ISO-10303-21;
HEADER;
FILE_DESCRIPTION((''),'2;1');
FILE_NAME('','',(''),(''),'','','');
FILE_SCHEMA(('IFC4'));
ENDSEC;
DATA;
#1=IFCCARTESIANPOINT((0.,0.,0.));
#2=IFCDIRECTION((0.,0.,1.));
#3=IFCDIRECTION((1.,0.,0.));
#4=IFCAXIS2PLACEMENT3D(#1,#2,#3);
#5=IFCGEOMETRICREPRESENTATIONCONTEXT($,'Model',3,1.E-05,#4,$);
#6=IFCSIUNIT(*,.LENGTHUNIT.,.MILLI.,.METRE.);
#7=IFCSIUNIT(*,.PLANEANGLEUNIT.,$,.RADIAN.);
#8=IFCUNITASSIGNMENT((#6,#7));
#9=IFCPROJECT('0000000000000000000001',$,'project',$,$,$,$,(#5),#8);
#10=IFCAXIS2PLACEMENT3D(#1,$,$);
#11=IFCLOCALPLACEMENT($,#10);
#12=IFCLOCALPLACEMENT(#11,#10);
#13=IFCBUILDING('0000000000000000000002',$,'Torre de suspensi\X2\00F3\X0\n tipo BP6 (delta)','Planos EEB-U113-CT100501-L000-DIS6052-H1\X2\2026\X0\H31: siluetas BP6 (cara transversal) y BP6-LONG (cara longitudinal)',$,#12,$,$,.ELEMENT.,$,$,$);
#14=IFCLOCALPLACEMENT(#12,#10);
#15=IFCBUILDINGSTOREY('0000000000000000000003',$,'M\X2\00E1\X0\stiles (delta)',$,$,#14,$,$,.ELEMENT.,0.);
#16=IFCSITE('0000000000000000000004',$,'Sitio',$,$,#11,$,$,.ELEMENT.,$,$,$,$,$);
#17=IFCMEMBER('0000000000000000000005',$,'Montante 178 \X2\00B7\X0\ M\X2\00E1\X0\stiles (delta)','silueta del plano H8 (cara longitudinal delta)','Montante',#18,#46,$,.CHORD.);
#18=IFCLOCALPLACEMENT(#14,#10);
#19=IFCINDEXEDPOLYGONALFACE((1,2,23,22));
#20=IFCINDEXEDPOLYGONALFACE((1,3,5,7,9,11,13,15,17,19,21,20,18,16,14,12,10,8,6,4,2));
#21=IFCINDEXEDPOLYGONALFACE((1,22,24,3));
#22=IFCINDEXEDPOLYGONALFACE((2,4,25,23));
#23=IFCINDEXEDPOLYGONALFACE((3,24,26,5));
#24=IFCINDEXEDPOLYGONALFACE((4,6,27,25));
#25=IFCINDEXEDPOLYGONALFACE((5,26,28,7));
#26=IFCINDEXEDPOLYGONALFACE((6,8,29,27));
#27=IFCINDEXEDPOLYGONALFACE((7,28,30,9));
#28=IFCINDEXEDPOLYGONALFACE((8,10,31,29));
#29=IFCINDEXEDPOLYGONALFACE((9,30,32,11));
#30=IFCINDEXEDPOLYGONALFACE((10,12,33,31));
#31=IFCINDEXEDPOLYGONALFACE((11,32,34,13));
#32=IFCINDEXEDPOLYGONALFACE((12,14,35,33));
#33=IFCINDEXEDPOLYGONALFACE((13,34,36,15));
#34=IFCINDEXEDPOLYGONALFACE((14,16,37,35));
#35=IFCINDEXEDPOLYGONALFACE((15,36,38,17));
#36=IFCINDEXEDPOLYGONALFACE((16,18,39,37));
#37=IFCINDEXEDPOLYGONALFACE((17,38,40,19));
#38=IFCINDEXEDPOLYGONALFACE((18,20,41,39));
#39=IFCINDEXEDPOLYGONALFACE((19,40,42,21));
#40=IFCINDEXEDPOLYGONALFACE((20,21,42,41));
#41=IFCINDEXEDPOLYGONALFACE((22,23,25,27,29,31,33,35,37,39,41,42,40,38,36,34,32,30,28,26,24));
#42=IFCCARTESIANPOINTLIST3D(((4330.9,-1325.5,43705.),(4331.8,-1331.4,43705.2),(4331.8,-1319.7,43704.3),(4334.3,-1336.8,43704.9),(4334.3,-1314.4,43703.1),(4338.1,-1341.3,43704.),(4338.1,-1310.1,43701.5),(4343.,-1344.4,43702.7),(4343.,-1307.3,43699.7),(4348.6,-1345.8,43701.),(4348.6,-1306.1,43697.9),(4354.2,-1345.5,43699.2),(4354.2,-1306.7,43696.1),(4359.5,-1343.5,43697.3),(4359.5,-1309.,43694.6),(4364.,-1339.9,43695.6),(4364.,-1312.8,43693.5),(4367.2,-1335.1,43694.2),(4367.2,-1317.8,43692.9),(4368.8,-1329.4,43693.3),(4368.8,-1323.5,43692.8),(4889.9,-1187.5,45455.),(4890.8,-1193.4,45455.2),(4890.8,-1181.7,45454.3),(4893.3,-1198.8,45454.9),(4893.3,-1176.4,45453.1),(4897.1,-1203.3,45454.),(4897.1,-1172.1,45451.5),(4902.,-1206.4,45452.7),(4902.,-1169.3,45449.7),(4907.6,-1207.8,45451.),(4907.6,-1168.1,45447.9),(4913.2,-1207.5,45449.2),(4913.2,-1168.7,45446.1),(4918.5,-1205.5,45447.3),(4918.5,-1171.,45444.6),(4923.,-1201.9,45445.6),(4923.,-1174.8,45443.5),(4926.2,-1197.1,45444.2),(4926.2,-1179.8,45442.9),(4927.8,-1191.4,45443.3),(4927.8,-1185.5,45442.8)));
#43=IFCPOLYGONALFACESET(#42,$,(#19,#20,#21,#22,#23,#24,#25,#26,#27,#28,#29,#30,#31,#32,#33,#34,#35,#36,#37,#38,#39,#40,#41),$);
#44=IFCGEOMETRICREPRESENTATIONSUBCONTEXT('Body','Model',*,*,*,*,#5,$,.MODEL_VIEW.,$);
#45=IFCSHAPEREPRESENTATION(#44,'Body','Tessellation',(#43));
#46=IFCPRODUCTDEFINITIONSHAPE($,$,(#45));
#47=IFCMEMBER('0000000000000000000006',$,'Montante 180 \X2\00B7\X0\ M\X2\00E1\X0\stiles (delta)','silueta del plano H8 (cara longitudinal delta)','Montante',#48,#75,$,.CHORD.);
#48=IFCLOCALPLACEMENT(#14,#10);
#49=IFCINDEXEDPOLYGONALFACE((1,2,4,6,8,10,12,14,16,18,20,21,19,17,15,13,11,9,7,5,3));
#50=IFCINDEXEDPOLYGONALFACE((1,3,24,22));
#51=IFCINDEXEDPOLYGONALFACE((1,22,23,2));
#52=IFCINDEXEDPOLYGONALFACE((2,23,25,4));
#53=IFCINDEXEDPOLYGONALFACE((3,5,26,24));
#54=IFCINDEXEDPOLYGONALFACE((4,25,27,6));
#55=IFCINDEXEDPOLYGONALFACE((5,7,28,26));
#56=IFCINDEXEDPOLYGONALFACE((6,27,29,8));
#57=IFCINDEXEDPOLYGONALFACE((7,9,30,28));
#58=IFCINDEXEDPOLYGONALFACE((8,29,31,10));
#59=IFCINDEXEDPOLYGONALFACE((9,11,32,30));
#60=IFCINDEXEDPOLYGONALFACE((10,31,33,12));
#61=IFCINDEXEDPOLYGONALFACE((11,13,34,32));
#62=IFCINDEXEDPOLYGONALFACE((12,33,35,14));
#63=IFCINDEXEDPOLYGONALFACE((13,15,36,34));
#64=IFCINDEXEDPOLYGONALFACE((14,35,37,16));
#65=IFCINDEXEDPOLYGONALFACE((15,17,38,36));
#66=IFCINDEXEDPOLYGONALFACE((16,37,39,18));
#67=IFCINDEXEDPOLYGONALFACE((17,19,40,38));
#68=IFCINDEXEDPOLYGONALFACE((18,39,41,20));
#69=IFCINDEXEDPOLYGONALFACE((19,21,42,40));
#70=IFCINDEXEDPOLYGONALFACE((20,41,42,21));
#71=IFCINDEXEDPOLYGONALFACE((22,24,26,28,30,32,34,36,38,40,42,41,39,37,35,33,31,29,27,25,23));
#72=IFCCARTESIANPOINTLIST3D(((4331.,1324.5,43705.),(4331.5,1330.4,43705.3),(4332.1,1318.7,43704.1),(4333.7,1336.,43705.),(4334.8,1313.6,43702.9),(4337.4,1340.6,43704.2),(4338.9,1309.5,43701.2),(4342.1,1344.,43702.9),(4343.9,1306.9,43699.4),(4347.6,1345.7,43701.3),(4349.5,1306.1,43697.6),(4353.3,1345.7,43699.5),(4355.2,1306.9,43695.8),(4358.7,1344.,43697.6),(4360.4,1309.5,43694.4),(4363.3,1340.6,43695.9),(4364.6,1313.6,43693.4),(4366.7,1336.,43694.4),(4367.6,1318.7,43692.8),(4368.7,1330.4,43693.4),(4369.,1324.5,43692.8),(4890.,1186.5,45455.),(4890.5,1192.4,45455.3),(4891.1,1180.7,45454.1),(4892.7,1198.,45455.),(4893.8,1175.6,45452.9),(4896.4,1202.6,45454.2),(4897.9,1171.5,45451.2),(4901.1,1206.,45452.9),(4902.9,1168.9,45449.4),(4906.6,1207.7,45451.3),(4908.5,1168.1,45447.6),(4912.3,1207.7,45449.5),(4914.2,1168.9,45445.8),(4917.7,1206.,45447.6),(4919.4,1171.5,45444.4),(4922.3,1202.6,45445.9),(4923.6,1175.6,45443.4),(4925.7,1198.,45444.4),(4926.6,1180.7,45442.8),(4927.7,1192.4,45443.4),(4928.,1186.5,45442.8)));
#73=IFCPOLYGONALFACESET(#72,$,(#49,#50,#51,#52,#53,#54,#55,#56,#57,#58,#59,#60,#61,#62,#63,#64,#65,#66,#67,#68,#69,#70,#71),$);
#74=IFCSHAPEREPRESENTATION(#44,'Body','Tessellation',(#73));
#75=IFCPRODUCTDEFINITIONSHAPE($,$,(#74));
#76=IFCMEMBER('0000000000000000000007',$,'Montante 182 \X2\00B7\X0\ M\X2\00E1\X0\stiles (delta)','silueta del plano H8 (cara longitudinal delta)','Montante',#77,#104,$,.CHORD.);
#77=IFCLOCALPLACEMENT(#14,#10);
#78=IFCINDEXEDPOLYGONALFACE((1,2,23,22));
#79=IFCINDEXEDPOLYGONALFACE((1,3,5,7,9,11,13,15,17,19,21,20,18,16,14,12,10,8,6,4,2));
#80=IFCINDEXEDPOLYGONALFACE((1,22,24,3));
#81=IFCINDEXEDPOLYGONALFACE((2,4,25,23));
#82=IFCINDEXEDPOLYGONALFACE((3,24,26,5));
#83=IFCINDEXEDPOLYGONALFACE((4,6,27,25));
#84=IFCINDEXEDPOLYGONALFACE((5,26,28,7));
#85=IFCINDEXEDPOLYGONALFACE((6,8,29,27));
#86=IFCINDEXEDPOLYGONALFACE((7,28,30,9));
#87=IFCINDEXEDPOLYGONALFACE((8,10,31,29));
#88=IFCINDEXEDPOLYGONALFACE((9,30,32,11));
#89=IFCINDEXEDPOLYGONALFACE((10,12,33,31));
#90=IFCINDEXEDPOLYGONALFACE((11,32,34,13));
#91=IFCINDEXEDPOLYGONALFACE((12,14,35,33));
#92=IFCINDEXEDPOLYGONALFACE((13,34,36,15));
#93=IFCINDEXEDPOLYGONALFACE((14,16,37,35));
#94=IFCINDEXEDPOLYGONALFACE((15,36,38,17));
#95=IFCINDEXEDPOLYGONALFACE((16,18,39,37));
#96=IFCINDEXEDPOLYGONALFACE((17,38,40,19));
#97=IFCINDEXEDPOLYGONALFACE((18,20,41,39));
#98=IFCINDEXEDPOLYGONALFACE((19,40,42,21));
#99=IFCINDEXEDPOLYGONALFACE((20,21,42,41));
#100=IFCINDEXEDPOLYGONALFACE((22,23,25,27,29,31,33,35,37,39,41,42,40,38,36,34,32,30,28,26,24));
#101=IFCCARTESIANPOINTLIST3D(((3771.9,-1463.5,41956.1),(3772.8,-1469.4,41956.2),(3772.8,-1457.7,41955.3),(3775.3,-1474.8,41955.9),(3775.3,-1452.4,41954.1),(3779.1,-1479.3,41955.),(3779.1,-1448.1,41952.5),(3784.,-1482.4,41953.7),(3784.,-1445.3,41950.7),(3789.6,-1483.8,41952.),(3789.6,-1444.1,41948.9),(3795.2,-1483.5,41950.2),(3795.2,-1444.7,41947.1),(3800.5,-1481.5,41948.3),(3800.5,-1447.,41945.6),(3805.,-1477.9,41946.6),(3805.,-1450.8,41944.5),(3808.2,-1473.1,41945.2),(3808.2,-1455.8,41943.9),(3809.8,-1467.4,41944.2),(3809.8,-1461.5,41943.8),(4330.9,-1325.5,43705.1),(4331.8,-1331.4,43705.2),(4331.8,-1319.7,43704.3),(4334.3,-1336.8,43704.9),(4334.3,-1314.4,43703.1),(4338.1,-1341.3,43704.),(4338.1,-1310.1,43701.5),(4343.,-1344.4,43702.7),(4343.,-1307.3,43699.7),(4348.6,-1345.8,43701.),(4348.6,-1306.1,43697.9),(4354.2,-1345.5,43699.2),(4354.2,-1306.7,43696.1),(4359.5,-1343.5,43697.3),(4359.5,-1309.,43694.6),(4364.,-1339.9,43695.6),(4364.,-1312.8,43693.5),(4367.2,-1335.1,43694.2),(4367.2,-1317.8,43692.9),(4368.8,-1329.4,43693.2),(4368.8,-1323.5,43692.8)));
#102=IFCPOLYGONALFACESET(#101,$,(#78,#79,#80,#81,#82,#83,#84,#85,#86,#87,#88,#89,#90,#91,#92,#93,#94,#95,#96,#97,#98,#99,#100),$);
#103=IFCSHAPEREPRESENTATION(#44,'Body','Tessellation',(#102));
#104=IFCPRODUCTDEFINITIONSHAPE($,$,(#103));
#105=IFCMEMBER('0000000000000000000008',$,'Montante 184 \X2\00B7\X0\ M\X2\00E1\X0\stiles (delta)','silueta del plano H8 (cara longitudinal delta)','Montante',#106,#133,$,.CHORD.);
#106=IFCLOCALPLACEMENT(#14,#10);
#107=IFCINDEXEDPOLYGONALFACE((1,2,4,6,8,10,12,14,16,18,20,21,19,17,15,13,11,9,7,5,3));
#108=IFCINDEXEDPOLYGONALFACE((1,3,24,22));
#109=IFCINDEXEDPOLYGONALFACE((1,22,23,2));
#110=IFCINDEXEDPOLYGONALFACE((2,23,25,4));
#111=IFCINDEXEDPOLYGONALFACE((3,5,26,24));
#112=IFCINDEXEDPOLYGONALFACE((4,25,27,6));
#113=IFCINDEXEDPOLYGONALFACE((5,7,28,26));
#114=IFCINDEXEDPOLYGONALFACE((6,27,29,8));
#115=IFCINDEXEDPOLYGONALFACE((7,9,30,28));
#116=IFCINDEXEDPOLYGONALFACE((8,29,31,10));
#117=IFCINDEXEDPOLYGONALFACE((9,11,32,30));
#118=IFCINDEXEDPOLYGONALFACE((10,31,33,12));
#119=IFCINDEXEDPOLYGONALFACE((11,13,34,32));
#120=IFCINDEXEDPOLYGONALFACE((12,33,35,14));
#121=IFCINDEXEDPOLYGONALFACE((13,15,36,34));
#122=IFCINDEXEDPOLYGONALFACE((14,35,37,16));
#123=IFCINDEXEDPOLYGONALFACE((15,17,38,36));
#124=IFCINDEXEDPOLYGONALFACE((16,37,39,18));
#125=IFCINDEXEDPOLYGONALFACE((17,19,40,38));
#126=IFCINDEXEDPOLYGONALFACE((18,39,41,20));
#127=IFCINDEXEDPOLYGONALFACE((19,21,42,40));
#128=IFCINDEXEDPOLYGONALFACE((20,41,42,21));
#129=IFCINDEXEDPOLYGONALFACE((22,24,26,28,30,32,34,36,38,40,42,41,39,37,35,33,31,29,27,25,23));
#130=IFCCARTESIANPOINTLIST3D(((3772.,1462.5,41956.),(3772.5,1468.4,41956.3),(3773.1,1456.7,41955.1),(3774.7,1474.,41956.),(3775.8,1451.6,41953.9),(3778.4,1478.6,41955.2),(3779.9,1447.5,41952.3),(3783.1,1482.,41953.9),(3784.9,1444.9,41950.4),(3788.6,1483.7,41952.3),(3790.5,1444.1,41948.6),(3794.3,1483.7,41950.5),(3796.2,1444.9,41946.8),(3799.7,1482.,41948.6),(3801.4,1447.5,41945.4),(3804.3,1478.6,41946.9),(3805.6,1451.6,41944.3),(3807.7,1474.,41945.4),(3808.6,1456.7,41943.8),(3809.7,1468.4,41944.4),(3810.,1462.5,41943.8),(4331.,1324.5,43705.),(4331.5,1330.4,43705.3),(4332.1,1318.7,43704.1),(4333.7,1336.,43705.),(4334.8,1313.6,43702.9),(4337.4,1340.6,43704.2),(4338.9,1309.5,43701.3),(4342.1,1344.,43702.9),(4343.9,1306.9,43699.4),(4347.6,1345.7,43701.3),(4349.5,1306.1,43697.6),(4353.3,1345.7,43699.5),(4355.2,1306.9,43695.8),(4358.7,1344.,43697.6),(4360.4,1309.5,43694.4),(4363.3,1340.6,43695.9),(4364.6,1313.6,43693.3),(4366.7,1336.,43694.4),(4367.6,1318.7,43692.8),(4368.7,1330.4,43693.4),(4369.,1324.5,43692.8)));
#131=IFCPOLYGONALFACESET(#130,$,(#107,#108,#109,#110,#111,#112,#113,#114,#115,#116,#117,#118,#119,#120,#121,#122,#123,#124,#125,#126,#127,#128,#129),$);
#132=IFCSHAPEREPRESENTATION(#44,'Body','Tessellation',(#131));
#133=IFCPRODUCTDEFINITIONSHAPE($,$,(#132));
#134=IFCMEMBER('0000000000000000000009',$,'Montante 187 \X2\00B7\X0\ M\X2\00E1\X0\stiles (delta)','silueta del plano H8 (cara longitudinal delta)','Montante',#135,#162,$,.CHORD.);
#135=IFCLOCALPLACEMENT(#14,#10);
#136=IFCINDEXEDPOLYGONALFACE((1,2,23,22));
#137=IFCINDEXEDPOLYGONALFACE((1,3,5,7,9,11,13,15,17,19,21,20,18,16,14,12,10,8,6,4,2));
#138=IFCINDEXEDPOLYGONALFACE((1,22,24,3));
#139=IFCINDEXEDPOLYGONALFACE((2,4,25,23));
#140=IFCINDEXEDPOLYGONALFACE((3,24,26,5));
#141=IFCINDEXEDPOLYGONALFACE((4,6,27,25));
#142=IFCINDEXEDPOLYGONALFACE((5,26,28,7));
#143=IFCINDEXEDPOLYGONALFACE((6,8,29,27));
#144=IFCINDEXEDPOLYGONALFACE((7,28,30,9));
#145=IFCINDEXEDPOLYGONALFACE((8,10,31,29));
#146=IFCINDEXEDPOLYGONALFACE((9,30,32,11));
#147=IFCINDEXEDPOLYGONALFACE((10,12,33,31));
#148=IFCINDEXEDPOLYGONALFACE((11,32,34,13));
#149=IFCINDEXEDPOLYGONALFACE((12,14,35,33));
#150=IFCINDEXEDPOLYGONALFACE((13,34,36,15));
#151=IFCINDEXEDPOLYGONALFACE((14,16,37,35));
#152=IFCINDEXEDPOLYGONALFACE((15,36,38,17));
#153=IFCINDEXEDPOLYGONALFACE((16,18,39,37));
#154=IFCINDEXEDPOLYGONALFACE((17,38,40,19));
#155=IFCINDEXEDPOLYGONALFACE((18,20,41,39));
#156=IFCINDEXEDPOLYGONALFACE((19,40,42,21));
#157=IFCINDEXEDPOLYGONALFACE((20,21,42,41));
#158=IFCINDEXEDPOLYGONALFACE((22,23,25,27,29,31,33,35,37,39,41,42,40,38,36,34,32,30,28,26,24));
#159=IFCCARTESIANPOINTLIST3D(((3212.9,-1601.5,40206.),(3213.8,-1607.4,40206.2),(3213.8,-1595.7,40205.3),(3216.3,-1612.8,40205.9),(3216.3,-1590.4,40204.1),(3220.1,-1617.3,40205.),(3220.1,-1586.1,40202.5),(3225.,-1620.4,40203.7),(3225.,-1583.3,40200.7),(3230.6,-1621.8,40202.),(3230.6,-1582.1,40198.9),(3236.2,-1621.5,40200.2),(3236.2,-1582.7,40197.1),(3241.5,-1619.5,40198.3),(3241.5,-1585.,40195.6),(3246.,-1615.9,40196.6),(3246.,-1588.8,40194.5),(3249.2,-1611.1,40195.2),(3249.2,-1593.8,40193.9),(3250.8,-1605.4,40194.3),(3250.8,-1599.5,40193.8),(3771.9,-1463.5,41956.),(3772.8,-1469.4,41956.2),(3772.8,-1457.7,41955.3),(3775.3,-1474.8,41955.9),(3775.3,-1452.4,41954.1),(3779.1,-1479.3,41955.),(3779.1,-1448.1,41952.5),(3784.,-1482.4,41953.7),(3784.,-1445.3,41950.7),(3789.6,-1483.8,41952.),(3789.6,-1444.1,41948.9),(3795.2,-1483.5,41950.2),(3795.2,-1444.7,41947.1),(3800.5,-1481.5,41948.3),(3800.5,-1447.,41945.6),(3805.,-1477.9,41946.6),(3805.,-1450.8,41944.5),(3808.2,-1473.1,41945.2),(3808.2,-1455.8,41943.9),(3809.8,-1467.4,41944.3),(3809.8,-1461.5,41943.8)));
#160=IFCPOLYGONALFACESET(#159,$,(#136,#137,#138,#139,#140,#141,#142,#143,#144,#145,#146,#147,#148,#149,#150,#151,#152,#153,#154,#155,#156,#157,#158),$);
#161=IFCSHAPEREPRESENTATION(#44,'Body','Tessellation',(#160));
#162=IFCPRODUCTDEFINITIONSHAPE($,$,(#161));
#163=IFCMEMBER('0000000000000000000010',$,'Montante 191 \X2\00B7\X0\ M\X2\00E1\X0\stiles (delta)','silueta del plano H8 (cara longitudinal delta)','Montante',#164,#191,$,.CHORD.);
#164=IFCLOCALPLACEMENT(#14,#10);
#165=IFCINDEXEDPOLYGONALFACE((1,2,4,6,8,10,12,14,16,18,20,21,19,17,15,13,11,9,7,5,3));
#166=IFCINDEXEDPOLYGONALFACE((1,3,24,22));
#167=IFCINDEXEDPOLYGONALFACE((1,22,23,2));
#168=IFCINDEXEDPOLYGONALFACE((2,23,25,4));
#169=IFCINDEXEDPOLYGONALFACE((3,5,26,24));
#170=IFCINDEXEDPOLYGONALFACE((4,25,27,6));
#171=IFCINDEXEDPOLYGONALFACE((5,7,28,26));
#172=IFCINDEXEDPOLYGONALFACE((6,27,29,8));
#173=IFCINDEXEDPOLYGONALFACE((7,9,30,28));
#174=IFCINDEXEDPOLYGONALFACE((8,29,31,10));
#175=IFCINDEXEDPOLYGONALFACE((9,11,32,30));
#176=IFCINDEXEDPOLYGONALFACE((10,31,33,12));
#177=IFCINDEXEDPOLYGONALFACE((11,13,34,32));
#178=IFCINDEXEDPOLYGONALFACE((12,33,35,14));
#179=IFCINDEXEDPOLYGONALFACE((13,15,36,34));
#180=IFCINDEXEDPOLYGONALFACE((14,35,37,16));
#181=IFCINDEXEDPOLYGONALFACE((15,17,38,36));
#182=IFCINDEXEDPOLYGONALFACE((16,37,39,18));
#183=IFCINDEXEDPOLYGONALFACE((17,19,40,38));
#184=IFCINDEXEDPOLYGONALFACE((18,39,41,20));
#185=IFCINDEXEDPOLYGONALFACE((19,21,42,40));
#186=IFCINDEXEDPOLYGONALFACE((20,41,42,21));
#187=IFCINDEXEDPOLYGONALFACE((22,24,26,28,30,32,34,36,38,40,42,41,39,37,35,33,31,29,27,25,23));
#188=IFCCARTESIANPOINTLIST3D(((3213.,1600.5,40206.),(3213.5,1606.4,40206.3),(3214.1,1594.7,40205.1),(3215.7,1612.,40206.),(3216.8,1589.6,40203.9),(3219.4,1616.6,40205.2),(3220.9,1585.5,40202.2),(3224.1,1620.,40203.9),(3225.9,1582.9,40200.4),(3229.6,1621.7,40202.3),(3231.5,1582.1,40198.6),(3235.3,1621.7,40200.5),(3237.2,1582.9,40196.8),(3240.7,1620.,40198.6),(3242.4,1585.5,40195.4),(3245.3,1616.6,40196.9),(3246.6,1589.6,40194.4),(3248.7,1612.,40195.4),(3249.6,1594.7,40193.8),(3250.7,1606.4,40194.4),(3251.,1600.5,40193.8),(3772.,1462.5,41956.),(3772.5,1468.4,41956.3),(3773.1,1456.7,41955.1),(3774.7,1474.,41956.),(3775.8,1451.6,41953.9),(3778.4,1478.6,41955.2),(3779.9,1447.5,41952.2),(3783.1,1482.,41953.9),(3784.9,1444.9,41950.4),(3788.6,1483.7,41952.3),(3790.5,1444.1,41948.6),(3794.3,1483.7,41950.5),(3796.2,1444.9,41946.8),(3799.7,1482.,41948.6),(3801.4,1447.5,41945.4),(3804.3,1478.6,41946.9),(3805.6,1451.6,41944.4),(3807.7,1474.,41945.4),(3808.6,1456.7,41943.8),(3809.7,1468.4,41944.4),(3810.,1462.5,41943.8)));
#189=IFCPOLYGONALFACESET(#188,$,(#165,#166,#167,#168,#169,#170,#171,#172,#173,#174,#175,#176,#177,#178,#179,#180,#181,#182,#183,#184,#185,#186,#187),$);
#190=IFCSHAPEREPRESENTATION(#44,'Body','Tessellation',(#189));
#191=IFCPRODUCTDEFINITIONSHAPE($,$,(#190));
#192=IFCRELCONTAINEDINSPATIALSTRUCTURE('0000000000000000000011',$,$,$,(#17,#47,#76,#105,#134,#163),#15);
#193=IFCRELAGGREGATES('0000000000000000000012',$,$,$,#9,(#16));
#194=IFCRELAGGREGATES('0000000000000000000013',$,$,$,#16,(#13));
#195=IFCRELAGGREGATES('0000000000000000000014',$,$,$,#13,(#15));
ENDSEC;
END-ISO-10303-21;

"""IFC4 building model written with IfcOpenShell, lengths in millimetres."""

from ifc_helpers import new_model, si_unit, frame, origin, origin_with_axes, place, context, subcontext, project, spatial, circle, extrude, element, save


model = new_model("IFC4")

# Units and contexts
model_context = context("Model", 3, precision=1e-05, world=origin_with_axes())
body_context = subcontext(model_context, "Body", "Model", "MODEL_VIEW")
ifc_project = project(units=[si_unit("LENGTHUNIT", "METRE", prefix="MILLI"), si_unit("PLANEANGLEUNIT", "RADIAN")], contexts=[model_context])

# Site, building, storey
site_placement = place(None, origin())
site = spatial("IfcSite", under=ifc_project, at=site_placement, Name="Sitio", CompositionType="ELEMENT")
building_placement = place(site_placement, origin())
building = spatial("IfcBuilding", under=site, at=building_placement, Name="Torre de suspensión tipo BP6 (delta)", Description="Planos EEB-U113-CT100501-L000-DIS6052-H1…H31: siluetas BP6 (cara transversal) y BP6-LONG (cara longitudinal)", CompositionType="ELEMENT")
storey_placement = place(building_placement, origin())
storey = spatial("IfcBuildingStorey", under=building, at=storey_placement, Name="Mástiles (delta)", CompositionType="ELEMENT", Elevation=0.0)

# Members
for number, where, z_axis, x_axis, name in (
    (1, (4909.0, -1188.0, 45449.0), (-0.303427, -0.074907, -0.949906), (-0.952855, 0.023853, 0.302488), "Montante 178 · Mástiles (delta)"),
    (2, (4909.0, 1188.0, 45449.0), (-0.303427, 0.074907, -0.949906), (-0.022793, -0.997191, -0.071355), "Montante 180 · Mástiles (delta)"),
):
    element("IfcMember", number, at=place(storey_placement, frame(where, z_axis=z_axis, x_axis=x_axis)), inside=storey, Name=name, Description="silueta del plano H8 (cara longitudinal delta)", ObjectType="Montante", PredefinedType="CHORD", context=body_context, shape_type="SweptSolid", body=[
        extrude(circle(Radius=20.0), None, (0.0, 0.0, 1.0), 1842.3),
    ])
for number, where, z_axis, x_axis, name in (
    (3, (4350.0, -1326.0, 43699.0), (-0.303584, -0.074945, -0.949853), (-0.952805, 0.023879, 0.302643), "Montante 182 · Mástiles (delta)"),
    (4, (4350.0, 1326.0, 43699.0), (-0.303584, 0.074945, -0.949853), (-0.022816, -0.997188, -0.071388), "Montante 184 · Mástiles (delta)"),
):
    element("IfcMember", number, at=place(storey_placement, frame(where, z_axis=z_axis, x_axis=x_axis)), inside=storey, Name=name, Description="silueta del plano H8 (cara longitudinal delta)", ObjectType="Montante", PredefinedType="CHORD", context=body_context, shape_type="SweptSolid", body=[
        extrude(circle(Radius=20.0), None, (0.0, 0.0, 1.0), 1841.3),
    ])
for number, where, z_axis, x_axis, name in (
    (5, (3791.0, -1464.0, 41950.0), (-0.303427, -0.074907, -0.949906), (-0.952855, 0.023853, 0.302488), "Montante 187 · Mástiles (delta)"),
    (6, (3791.0, 1464.0, 41950.0), (-0.303427, 0.074907, -0.949906), (-0.022793, -0.997191, -0.071355), "Montante 191 · Mástiles (delta)"),
):
    element("IfcMember", number, at=place(storey_placement, frame(where, z_axis=z_axis, x_axis=x_axis)), inside=storey, Name=name, Description="silueta del plano H8 (cara longitudinal delta)", ObjectType="Montante", PredefinedType="CHORD", context=body_context, shape_type="SweptSolid", body=[
        extrude(circle(Radius=20.0), None, (0.0, 0.0, 1.0), 1842.3),
    ])

save(model, "model.ifc")
